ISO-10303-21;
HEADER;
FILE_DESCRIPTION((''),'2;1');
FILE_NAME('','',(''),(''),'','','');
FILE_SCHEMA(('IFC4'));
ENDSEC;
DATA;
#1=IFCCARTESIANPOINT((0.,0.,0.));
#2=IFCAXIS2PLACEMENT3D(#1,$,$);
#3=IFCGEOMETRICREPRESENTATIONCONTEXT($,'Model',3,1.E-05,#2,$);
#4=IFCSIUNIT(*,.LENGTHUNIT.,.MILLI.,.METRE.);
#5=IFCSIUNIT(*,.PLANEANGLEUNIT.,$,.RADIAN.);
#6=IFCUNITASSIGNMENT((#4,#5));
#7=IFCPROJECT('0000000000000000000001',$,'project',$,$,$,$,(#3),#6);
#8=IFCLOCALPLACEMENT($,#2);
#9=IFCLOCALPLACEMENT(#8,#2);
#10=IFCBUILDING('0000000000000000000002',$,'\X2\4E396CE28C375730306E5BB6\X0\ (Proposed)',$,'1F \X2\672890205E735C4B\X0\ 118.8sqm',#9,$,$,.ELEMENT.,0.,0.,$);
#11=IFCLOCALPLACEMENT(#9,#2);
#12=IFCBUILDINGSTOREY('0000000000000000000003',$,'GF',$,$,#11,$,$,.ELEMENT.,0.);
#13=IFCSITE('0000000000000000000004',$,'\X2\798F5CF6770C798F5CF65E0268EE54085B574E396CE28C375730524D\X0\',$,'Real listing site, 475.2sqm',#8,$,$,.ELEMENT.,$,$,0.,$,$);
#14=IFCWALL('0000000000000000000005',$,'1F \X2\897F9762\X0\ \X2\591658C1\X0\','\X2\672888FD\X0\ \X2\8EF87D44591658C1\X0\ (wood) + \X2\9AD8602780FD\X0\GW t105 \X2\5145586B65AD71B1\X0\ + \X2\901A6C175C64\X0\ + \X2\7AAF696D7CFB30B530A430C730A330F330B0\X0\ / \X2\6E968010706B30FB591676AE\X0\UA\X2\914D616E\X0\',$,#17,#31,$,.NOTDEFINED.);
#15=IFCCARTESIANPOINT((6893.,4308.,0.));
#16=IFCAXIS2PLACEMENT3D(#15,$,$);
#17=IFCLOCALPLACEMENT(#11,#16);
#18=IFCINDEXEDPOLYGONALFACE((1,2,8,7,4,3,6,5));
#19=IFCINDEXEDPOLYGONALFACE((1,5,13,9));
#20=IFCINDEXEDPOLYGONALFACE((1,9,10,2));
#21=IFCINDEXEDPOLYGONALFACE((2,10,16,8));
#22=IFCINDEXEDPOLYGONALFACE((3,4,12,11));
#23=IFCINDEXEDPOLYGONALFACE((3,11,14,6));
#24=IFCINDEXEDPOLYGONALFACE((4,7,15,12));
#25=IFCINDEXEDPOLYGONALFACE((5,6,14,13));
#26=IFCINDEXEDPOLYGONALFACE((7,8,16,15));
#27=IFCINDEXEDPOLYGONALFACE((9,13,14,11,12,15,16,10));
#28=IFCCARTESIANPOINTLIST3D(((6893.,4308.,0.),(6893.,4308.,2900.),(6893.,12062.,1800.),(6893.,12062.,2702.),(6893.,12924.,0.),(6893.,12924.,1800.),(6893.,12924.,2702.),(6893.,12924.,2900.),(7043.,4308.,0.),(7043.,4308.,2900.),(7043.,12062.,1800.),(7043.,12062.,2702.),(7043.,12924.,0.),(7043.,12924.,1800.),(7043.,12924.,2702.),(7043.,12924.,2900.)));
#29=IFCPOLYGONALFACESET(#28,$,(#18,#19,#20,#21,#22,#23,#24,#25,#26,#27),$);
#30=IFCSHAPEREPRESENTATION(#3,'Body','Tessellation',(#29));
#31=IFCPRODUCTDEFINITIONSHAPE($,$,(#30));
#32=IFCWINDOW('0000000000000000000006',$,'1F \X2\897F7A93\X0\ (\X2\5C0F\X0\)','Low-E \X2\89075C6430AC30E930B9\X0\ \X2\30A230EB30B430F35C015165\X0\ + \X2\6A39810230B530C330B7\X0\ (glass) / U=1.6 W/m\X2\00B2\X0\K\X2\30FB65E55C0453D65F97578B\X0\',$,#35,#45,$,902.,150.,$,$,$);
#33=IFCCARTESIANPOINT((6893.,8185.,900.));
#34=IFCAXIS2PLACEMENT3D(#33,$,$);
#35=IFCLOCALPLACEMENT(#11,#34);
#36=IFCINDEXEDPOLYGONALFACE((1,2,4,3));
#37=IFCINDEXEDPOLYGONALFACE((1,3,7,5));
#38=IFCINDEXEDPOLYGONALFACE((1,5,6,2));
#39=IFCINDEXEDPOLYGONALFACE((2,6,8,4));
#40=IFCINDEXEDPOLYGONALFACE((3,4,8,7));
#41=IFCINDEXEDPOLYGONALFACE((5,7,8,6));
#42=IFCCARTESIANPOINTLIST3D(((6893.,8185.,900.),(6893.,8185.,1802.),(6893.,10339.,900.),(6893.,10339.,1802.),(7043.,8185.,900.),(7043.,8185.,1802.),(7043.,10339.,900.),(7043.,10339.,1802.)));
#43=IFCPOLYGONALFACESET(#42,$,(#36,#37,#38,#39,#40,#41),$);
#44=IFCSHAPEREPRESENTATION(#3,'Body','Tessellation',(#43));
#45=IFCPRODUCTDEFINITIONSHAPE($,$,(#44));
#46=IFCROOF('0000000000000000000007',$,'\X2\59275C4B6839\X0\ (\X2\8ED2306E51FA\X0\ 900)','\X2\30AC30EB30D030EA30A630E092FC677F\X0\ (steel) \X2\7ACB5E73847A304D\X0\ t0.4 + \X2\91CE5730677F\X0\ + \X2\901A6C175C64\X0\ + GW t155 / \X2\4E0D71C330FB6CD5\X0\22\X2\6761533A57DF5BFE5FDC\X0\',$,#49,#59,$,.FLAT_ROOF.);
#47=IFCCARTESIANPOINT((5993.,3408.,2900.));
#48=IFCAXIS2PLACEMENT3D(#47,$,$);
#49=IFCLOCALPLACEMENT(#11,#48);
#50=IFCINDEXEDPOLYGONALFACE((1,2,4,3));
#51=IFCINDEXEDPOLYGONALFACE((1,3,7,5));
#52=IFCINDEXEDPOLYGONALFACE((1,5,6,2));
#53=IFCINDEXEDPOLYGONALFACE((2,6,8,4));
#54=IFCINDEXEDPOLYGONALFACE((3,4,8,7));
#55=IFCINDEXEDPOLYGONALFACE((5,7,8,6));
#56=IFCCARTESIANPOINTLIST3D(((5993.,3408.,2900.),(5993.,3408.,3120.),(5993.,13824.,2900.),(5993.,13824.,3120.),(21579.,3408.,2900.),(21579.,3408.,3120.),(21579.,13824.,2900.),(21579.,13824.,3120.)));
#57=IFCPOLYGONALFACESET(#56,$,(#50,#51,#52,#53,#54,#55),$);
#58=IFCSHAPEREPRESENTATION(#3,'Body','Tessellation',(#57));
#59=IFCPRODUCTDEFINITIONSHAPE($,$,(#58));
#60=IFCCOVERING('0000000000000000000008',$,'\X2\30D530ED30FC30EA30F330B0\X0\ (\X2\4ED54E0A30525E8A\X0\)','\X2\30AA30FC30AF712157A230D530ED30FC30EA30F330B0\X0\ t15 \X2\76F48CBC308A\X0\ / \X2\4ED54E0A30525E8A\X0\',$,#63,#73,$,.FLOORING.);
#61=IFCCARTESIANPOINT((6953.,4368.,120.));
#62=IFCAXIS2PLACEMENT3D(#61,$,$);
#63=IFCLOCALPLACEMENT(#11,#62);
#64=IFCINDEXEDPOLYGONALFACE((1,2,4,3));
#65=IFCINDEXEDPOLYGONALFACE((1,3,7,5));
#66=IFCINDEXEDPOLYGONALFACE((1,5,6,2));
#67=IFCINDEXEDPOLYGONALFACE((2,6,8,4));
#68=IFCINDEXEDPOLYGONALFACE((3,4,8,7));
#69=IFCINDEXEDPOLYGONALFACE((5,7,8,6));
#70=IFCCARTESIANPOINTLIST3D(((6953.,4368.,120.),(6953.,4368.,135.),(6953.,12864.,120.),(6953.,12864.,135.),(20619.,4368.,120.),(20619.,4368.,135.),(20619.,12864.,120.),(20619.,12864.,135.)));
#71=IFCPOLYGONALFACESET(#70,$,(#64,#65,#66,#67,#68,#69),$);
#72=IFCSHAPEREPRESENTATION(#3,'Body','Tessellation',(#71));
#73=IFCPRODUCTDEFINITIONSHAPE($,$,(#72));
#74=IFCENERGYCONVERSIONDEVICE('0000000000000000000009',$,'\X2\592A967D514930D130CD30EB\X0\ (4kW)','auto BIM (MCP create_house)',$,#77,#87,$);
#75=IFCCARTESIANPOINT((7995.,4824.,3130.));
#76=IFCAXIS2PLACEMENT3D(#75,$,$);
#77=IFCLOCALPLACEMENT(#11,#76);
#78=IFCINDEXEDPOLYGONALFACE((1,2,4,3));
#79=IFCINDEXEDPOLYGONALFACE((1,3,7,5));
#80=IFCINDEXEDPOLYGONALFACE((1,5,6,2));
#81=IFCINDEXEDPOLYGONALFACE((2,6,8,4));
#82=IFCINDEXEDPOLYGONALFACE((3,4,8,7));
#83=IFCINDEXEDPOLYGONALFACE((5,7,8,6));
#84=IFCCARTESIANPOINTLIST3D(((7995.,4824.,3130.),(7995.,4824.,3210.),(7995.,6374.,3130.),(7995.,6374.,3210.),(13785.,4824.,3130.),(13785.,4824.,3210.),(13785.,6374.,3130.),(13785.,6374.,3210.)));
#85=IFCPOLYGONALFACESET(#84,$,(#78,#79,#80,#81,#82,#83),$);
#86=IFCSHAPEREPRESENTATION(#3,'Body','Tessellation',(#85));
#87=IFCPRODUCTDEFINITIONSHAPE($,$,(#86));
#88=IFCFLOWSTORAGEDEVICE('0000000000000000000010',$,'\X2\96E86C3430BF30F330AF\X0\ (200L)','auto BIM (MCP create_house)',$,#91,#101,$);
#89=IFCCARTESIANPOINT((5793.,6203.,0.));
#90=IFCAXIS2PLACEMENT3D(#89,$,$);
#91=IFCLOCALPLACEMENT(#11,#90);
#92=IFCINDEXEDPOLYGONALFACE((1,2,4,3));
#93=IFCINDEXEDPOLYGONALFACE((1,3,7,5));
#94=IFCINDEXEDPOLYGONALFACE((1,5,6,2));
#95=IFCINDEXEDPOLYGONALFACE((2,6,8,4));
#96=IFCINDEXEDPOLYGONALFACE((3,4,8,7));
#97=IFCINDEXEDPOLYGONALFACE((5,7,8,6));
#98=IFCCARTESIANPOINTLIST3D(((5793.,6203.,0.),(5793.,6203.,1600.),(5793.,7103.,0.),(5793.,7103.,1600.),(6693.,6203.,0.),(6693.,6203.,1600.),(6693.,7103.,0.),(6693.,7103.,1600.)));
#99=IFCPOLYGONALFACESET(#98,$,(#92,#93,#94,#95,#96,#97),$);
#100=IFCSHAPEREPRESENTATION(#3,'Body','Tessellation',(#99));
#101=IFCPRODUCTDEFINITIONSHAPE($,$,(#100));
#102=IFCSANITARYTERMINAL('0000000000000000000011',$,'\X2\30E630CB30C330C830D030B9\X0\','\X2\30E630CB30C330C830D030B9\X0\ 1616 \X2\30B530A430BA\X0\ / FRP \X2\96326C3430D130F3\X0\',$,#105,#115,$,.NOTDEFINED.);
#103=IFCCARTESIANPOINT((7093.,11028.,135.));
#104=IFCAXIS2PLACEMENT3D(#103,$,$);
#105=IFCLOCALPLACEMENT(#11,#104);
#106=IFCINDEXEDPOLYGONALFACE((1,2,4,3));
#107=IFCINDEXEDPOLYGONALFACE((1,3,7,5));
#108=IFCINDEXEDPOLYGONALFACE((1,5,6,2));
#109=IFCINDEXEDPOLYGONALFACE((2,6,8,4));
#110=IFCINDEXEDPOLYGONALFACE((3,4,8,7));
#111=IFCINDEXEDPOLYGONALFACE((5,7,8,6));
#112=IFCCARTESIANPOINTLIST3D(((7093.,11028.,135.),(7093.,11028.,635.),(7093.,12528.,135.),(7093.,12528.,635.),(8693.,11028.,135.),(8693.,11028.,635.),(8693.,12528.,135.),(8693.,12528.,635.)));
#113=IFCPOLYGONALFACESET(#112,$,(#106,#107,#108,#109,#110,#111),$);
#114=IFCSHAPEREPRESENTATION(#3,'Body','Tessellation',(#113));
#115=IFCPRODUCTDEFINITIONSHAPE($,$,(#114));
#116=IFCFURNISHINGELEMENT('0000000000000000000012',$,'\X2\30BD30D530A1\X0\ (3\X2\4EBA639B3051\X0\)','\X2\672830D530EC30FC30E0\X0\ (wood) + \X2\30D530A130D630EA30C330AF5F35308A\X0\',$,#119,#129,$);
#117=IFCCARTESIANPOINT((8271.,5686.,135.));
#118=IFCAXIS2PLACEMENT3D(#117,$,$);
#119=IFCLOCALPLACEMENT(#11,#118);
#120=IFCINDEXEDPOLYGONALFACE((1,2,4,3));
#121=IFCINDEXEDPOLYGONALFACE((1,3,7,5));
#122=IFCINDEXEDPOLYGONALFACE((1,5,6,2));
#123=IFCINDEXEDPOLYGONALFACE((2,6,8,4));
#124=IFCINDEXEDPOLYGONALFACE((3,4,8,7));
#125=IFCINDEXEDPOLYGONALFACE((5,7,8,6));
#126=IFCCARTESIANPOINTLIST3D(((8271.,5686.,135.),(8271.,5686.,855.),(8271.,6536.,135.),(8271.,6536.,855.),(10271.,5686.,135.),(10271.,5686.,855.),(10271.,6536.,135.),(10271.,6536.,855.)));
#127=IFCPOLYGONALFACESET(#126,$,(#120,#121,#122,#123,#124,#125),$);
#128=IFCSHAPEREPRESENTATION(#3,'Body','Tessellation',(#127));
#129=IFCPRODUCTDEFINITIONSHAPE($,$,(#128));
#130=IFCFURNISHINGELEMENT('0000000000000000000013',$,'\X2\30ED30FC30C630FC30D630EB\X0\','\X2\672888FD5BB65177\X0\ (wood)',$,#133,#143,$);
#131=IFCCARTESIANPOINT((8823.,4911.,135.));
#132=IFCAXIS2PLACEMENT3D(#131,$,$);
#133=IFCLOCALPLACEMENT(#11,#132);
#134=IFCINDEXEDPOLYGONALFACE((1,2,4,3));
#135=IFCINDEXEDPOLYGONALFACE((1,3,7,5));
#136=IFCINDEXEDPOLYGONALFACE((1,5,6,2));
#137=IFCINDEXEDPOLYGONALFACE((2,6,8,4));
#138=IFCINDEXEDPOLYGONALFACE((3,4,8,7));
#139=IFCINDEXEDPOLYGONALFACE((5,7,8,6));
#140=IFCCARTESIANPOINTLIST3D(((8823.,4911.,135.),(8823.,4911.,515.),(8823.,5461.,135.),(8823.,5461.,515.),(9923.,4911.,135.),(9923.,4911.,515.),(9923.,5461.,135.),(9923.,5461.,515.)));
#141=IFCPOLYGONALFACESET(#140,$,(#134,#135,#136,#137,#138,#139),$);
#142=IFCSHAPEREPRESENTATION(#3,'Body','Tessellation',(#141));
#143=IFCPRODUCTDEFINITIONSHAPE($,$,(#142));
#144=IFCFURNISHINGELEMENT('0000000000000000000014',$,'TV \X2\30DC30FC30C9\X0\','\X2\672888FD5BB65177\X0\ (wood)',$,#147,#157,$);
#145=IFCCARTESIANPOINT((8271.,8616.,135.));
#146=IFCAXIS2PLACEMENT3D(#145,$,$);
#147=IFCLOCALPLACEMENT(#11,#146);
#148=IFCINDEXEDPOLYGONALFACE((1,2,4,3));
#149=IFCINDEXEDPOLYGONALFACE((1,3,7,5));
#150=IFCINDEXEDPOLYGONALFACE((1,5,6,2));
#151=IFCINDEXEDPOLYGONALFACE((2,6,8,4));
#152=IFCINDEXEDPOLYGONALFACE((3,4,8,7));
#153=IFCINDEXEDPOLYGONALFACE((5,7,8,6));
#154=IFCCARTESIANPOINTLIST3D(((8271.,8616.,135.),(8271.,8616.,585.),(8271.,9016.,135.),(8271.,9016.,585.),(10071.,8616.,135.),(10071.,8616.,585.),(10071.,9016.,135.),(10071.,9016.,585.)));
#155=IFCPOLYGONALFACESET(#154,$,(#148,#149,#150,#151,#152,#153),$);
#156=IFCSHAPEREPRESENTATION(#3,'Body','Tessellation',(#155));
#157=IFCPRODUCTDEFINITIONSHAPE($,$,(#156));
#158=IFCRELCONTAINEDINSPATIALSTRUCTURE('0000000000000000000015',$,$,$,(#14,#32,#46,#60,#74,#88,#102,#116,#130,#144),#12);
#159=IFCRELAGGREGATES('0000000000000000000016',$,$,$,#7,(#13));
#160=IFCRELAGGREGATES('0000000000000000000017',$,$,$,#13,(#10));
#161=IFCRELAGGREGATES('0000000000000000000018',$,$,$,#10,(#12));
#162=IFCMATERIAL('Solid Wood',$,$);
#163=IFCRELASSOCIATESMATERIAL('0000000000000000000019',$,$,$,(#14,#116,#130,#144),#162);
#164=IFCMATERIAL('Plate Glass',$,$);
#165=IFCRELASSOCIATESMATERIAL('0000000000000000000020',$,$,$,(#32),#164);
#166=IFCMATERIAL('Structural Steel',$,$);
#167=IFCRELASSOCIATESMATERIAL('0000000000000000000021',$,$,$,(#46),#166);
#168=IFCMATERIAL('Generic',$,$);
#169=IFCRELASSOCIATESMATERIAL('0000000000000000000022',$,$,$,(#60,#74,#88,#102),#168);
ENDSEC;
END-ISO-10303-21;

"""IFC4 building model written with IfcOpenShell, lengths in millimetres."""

from ifc_helpers import new_model, si_unit, frame, frame_2d, origin, place, context, project, spatial, rectangle, extrude, material, element, fill, save


model = new_model("IFC4")

# Units and contexts
model_context = context("Model", 3, precision=1e-05, world=origin())
ifc_project = project(units=[si_unit("LENGTHUNIT", "METRE", prefix="MILLI"), si_unit("PLANEANGLEUNIT", "RADIAN")], contexts=[model_context])

# Site, building, storey
site_placement = place(None, origin())
site = spatial("IfcSite", under=ifc_project, at=site_placement, Name="福島県福島市森合字丹波谷地前", ObjectType="Real listing site, 475.2sqm", CompositionType="ELEMENT", RefElevation=0.0)
building_placement = place(site_placement, origin())
building = spatial("IfcBuilding", under=site, at=building_placement, Name="丹波谷地の家 (Proposed)", ObjectType="1F 木造平屋 118.8sqm", CompositionType="ELEMENT", ElevationOfRefHeight=0.0, ElevationOfTerrain=0.0)
storey_placement = place(building_placement, origin())
storey = spatial("IfcBuildingStorey", under=building, at=storey_placement, Name="GF", CompositionType="ELEMENT", Elevation=0.0)

# Shared definitions
ifc_material_1 = material(Name="Solid Wood")

# Shared definitions
ifc_material_2 = material(Name="Plate Glass")

# Wall, opening, window
wall_1_placement = place(storey_placement, frame((6893.0, 4308.0, 0.0)))
wall_1 = element("IfcWall", 1, at=wall_1_placement, inside=storey, material=ifc_material_1, Name="1F 西面 外壁", Description="木製 軸組外壁 (wood) + 高性能GW t105 充填断熱 + 通気層 + 窯業系サイディング / 準耐火・外皮UA配慮", PredefinedType="NOTDEFINED", context=model_context, shape_type="SweptSolid", body=[
    extrude(rectangle(XDim=150.0, YDim=8616.0, at=frame_2d((75.0, 4308.0))), frame((6893.0, 4308.0, 0.0)), (0.0, 0.0, 1.0), 2900.0),
])
opening_1_placement = place(storey_placement, frame((6893.0, 8185.0, 900.0)))
opening_1 = element("IfcOpeningElement", 2, at=opening_1_placement, cuts=wall_1, PredefinedType="NOTDEFINED", context=model_context, shape_type="SweptSolid", body=[
    extrude(rectangle(XDim=150.0, YDim=2154.0, at=frame_2d((75.0, 1077.0))), frame((6893.0, 8185.0, 900.0)), (0.0, 0.0, 1.0), 902.0),
])
window_1_placement = place(storey_placement, frame((6893.0, 8185.0, 900.0)))
window_1 = element("IfcWindow", 3, at=window_1_placement, inside=storey, material=ifc_material_2, Name="1F 西窓 (小)", Description="Low-E 複層ガラス アルゴン封入 + 樹脂サッシ (glass) / U=1.6 W/m²K・日射取得型", OverallHeight=902.0, OverallWidth=150.0, context=model_context, shape_type="SweptSolid", body=[
    extrude(rectangle(XDim=150.0, YDim=2154.0, at=frame_2d((75.0, 1077.0))), frame((6893.0, 8185.0, 900.0)), (0.0, 0.0, 1.0), 902.0),
])
fill(opening_1, window_1)

# Roof
ifc_material_3 = material(Name="Structural Steel")
roof_placement = place(storey_placement, frame((5993.0, 3408.0, 2900.0)))
element("IfcRoof", 4, at=roof_placement, inside=storey, material=ifc_material_3, Name="大屋根 (軒の出 900)", Description="ガルバリウム鋼板 (steel) 立平葺き t0.4 + 野地板 + 通気層 + GW t155 / 不燃・法22条区域対応", PredefinedType="FLAT_ROOF", context=model_context, shape_type="SweptSolid", body=[
    extrude(rectangle(XDim=15586.0, YDim=10416.0, at=frame_2d((7793.0, 5208.0))), frame((5993.0, 3408.0, 2900.0)), (0.0, 0.0, 1.0), 220.0),
])

# Covering
ifc_material_4 = material(Name="Generic")
covering_placement = place(storey_placement, frame((6953.0, 4368.0, 120.0)))
element("IfcCovering", 5, at=covering_placement, inside=storey, material=ifc_material_4, Name="フローリング (仕上げ床)", Description="オーク無垢フローリング t15 直貼り / 仕上げ床", PredefinedType="FLOORING", context=model_context, shape_type="SweptSolid", body=[
    extrude(rectangle(XDim=13666.0, YDim=8496.0, at=frame_2d((6833.0, 4248.0))), frame((6953.0, 4368.0, 120.0)), (0.0, 0.0, 1.0), 15.0),
])

# Energy conversion device
energy_conversion_device_placement = place(storey_placement, frame((7995.0, 4824.0, 3130.0)))
element("IfcEnergyConversionDevice", 6, at=energy_conversion_device_placement, inside=storey, material=ifc_material_4, Name="太陽光パネル (4kW)", Description="auto BIM (MCP create_house)", context=model_context, shape_type="SweptSolid", body=[
    extrude(rectangle(XDim=5790.0, YDim=1550.0, at=frame_2d((2895.0, 775.0))), frame((7995.0, 4824.0, 3130.0)), (0.0, 0.0, 1.0), 80.0),
])

# Flow storage device
flow_storage_device_placement = place(storey_placement, frame((5793.0, 6203.0, 0.0)))
element("IfcFlowStorageDevice", 7, at=flow_storage_device_placement, inside=storey, material=ifc_material_4, Name="雨水タンク (200L)", Description="auto BIM (MCP create_house)", context=model_context, shape_type="SweptSolid", body=[
    extrude(rectangle(XDim=900.0, YDim=900.0, at=frame_2d((450.0, 450.0))), frame((5793.0, 6203.0, 0.0)), (0.0, 0.0, 1.0), 1600.0),
])

# Sanitary terminal
sanitary_terminal_placement = place(storey_placement, frame((7093.0, 11028.0, 135.0)))
element("IfcSanitaryTerminal", 8, at=sanitary_terminal_placement, inside=storey, material=ifc_material_4, Name="ユニットバス", Description="ユニットバス 1616 サイズ / FRP 防水パン", PredefinedType="NOTDEFINED", context=model_context, shape_type="SweptSolid", body=[
    extrude(rectangle(XDim=1600.0, YDim=1500.0, at=frame_2d((800.0, 750.0))), frame((7093.0, 11028.0, 135.0)), (0.0, 0.0, 1.0), 500.0),
])

# Furnishing elements
furnishing_1_placement = place(storey_placement, frame((8271.0, 5686.0, 135.0)))
element("IfcFurnishingElement", 9, at=furnishing_1_placement, inside=storey, material=ifc_material_1, Name="ソファ (3人掛け)", Description="木フレーム (wood) + ファブリック張り", context=model_context, shape_type="SweptSolid", body=[
    extrude(rectangle(XDim=2000.0, YDim=850.0, at=frame_2d((1000.0, 425.0))), frame((8271.0, 5686.0, 135.0)), (0.0, 0.0, 1.0), 720.0),
])
furnishing_2_placement = place(storey_placement, frame((8823.0, 4911.0, 135.0)))
element("IfcFurnishingElement", 10, at=furnishing_2_placement, inside=storey, material=ifc_material_1, Name="ローテーブル", Description="木製家具 (wood)", context=model_context, shape_type="SweptSolid", body=[
    extrude(rectangle(XDim=1100.0, YDim=550.0, at=frame_2d((550.0, 275.0))), frame((8823.0, 4911.0, 135.0)), (0.0, 0.0, 1.0), 380.0),
])
furnishing_3_placement = place(storey_placement, frame((8271.0, 8616.0, 135.0)))
element("IfcFurnishingElement", 11, at=furnishing_3_placement, inside=storey, material=ifc_material_1, Name="TV ボード", Description="木製家具 (wood)", context=model_context, shape_type="SweptSolid", body=[
    extrude(rectangle(XDim=1800.0, YDim=400.0, at=frame_2d((900.0, 200.0))), frame((8271.0, 8616.0, 135.0)), (0.0, 0.0, 1.0), 450.0),
])

save(model, "model.ifc")
